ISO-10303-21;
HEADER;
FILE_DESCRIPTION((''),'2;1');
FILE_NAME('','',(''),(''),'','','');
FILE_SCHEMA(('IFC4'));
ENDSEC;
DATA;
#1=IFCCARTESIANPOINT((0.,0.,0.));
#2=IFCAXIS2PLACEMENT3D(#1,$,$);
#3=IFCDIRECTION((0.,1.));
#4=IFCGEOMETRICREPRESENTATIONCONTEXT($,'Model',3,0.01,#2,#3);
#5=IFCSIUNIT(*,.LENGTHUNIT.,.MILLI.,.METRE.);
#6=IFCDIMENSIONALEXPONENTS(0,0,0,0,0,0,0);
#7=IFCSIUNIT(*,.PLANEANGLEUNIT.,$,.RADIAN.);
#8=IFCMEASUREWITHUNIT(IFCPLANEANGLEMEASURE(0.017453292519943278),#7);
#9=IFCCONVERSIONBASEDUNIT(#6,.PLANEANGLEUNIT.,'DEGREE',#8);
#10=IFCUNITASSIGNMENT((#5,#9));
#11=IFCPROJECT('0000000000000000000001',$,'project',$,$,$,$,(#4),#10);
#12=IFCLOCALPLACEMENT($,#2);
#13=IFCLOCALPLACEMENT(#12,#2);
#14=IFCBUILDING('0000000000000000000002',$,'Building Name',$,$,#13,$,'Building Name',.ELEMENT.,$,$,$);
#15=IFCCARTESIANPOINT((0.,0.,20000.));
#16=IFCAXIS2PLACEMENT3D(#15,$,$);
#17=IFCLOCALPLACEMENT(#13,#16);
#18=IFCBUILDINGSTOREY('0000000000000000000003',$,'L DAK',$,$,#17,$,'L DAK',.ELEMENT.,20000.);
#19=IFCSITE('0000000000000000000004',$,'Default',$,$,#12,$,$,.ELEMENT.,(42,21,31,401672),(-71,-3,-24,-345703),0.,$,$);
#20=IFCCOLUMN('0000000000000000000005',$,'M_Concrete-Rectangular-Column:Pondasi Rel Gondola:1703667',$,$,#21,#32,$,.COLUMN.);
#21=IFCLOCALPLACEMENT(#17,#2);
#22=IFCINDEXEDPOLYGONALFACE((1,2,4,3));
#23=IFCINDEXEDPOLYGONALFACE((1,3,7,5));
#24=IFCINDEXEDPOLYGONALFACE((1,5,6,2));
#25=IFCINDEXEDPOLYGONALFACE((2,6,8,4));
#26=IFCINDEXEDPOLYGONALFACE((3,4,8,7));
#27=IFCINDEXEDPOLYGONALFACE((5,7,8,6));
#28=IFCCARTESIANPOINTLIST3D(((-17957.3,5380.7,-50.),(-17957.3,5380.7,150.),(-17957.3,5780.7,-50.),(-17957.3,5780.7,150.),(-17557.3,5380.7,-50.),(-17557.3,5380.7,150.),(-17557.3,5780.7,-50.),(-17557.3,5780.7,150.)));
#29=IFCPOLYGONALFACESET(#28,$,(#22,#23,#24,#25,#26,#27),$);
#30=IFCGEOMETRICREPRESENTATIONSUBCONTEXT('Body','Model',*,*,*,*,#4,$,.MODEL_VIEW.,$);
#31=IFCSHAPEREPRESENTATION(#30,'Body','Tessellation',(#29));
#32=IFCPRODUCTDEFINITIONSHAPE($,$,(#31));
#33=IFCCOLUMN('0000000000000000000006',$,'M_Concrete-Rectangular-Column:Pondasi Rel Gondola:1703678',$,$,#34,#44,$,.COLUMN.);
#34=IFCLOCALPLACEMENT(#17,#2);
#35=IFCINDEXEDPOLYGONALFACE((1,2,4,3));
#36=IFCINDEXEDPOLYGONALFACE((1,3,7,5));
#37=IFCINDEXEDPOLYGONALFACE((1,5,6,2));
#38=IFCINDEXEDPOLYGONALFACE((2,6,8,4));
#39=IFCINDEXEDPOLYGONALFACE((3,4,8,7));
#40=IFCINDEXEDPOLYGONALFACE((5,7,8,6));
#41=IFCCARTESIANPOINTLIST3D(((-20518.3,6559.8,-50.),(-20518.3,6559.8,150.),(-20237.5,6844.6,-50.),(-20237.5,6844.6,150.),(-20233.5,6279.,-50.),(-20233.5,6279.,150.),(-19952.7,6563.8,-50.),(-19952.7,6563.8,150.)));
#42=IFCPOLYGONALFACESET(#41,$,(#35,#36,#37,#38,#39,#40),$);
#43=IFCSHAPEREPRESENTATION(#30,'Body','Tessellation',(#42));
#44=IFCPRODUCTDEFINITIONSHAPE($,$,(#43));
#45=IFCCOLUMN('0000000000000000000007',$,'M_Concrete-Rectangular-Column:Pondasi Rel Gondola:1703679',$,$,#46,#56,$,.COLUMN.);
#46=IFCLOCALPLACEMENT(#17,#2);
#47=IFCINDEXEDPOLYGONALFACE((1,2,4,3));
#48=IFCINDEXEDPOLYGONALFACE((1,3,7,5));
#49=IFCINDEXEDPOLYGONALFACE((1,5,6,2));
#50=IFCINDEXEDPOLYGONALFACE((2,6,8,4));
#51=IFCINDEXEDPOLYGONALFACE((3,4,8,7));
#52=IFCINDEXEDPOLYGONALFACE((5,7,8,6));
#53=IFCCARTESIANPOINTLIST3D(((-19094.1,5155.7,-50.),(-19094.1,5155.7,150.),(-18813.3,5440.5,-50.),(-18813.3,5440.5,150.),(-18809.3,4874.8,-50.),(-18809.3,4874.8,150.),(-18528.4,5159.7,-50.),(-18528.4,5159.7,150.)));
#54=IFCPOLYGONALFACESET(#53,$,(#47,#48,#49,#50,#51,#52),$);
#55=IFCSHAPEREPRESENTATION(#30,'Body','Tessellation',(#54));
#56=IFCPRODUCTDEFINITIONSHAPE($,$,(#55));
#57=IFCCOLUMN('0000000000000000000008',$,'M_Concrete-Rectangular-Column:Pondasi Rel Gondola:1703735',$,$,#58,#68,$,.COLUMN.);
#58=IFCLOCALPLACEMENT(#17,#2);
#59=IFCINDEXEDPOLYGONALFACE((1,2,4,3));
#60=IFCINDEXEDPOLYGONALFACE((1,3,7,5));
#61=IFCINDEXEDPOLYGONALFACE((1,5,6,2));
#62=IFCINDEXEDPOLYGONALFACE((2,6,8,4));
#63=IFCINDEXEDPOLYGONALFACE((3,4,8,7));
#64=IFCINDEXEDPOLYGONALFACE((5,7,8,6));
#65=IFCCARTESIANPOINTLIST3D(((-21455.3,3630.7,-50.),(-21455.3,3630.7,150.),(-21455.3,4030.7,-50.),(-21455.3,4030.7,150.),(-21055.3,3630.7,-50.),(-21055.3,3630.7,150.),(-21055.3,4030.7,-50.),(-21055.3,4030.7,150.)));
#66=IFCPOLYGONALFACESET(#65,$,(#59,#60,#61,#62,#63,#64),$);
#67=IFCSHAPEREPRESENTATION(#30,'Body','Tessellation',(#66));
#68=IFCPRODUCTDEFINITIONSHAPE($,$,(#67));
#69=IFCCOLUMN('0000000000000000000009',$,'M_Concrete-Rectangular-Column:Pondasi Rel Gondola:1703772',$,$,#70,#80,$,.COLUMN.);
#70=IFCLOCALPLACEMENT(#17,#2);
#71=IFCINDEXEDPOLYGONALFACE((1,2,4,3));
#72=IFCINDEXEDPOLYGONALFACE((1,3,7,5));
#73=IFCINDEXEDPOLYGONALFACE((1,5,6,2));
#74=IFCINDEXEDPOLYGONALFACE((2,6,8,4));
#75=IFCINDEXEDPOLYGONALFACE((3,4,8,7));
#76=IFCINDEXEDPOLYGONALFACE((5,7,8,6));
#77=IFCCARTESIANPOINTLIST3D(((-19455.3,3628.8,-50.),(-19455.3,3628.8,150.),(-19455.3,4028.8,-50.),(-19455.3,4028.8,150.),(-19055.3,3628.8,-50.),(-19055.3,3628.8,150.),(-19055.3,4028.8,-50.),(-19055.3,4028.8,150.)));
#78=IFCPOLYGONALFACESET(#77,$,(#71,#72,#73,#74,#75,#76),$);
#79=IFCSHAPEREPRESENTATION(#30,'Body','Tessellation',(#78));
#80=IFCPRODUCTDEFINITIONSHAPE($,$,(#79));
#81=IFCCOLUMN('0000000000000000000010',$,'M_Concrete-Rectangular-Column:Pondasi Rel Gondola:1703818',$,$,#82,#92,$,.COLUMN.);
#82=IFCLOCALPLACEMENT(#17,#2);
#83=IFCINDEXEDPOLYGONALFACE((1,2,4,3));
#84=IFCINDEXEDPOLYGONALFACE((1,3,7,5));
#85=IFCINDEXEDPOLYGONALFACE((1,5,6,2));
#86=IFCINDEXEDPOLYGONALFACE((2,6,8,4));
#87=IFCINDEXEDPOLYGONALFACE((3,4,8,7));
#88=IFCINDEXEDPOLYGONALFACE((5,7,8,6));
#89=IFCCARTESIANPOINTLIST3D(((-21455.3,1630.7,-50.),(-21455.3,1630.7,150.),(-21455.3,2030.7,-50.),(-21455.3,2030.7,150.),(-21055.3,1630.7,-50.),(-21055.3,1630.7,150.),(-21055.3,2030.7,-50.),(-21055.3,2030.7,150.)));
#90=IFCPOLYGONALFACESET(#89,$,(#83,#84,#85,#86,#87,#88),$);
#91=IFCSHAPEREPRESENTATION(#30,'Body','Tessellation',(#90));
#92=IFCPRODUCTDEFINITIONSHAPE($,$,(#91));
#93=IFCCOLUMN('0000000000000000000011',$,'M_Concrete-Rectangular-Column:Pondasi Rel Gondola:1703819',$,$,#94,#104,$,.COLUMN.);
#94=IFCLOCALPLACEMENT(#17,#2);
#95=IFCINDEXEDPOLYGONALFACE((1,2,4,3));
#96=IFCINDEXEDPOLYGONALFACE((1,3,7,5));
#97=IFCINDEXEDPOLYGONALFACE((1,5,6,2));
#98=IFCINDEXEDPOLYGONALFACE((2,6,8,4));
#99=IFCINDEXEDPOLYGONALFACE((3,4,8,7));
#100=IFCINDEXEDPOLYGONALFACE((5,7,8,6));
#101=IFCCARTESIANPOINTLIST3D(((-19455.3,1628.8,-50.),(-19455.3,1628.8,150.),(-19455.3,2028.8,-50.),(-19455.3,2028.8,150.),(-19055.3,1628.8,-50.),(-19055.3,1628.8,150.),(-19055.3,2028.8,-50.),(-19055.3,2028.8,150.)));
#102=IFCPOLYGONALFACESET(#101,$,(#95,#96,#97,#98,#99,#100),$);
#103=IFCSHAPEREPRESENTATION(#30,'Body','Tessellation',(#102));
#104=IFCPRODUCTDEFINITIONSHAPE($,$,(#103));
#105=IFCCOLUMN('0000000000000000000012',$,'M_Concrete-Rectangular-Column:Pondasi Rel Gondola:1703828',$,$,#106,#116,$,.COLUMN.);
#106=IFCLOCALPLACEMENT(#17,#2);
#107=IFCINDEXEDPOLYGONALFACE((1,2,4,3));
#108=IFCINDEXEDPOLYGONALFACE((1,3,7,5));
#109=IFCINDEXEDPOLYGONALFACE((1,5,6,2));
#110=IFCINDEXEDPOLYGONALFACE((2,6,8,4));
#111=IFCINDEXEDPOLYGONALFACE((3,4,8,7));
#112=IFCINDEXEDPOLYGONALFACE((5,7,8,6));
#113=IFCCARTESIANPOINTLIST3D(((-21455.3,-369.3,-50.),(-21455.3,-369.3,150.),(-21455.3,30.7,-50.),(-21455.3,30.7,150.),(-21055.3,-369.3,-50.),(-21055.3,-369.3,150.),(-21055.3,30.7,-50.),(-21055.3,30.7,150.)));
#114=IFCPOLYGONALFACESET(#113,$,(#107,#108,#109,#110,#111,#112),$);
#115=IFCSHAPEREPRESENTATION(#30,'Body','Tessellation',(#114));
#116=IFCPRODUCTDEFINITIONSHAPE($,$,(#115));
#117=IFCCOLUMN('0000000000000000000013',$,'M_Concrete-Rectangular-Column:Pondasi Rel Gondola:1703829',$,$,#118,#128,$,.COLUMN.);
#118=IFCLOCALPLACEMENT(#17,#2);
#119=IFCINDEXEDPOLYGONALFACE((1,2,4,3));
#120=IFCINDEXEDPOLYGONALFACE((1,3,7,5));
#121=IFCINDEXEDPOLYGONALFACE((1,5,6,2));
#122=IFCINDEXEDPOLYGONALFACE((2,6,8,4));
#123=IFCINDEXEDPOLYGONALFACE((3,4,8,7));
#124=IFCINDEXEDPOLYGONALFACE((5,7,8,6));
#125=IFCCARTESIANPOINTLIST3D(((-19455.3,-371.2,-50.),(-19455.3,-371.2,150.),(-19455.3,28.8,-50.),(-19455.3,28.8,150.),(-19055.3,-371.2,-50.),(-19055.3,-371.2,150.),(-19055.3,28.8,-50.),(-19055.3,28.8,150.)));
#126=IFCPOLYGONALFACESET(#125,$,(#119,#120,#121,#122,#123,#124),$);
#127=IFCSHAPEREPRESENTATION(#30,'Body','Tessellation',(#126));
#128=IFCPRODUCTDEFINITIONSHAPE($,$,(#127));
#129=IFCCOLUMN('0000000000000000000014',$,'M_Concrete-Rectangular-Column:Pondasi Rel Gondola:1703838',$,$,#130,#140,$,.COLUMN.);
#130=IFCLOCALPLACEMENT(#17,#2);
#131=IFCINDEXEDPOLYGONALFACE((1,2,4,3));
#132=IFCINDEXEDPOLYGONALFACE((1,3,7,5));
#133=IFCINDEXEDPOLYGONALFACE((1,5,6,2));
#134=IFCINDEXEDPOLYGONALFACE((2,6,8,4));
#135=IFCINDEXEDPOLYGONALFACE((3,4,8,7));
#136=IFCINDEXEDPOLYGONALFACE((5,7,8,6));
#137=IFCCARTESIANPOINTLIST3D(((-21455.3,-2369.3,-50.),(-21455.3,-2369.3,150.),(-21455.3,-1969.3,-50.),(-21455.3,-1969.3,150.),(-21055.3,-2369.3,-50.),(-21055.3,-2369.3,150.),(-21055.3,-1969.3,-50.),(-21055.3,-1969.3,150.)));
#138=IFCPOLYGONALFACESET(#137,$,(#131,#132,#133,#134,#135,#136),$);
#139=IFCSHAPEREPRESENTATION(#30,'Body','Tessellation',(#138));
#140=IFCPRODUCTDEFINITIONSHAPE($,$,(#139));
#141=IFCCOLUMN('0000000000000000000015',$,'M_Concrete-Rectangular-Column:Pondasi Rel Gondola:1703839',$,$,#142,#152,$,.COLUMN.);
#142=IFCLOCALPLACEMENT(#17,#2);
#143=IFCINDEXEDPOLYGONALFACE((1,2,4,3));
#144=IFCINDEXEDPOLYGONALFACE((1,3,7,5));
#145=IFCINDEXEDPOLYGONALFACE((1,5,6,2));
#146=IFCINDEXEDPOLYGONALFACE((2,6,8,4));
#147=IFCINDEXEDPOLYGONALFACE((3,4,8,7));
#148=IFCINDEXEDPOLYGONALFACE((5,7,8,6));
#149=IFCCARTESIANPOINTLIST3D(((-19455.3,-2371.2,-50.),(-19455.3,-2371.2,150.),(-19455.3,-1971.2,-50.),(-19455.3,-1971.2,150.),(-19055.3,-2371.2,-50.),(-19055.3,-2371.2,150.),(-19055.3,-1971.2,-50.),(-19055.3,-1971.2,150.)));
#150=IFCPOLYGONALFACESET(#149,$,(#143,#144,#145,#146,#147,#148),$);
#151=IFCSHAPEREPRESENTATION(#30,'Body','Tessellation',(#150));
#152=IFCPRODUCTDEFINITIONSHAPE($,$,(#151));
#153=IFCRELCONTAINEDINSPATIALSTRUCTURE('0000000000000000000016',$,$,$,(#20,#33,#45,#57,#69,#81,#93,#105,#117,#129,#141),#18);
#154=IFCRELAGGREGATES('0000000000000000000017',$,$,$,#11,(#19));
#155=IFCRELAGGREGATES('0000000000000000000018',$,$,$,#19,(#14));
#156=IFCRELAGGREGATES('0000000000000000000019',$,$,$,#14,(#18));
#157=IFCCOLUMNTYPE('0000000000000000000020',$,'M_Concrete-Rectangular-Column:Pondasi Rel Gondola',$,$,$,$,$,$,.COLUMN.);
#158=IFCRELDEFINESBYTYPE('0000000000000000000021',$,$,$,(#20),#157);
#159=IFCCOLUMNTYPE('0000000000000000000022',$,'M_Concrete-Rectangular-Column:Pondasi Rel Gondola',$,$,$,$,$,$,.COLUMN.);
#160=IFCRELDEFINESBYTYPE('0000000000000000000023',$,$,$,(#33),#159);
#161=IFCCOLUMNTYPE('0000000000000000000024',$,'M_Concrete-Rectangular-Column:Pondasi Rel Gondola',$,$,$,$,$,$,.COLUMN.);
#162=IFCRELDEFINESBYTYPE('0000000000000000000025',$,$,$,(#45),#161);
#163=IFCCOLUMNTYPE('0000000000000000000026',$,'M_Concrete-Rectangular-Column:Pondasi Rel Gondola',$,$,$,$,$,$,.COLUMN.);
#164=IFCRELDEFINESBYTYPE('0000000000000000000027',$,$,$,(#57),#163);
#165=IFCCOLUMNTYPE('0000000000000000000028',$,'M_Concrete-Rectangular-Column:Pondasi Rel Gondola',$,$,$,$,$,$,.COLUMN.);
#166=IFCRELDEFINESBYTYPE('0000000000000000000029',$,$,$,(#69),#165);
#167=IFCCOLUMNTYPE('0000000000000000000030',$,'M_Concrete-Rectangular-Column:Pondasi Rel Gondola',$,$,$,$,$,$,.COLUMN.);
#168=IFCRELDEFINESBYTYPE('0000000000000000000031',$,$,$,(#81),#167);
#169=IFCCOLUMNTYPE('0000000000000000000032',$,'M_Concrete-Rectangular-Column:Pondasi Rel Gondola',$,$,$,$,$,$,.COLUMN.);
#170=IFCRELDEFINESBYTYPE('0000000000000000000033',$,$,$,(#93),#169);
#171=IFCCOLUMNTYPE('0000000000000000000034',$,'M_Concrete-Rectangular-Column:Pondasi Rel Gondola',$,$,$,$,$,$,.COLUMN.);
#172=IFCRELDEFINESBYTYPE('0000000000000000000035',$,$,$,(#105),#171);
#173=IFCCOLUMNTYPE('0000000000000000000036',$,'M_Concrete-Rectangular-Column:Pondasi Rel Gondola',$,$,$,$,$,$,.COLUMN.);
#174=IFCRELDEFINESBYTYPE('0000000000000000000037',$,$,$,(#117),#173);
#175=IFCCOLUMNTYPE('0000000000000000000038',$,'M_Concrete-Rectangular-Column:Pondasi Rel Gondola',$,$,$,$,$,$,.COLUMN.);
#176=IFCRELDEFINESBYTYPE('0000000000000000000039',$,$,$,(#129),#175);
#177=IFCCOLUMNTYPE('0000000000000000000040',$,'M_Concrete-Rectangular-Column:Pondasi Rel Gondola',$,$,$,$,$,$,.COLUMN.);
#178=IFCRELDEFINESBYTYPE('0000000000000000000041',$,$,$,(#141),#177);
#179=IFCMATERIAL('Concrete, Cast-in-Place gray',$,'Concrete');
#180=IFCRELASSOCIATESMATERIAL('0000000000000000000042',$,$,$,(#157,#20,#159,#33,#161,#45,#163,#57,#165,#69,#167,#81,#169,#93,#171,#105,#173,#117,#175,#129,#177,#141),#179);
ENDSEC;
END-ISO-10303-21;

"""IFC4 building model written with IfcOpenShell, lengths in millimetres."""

from ifc_helpers import new_model, entity, si_unit, converted_unit, direction, frame, origin, place, context, subcontext, project, spatial, indexed_curve, outline, extrude, source, transform, mapped, material, type_object, type_shapes, element, save


model = new_model("IFC4")

# Units and contexts
model_context = context("Model", 3, precision=0.01, world=origin(), true_north=direction((0.0, 1.0)))
body_context = subcontext(model_context, "Body", "Model", "MODEL_VIEW")
ifc_project = project(units=[si_unit("LENGTHUNIT", "METRE", prefix="MILLI"), converted_unit("PLANEANGLEUNIT", "DEGREE", entity("IfcPlaneAngleMeasure", 0.017453292519943278), si_unit("PLANEANGLEUNIT", "RADIAN"), dimensions=[0, 0, 0, 0, 0, 0, 0])], contexts=[model_context])

# Site, building, storey
site_placement = place(None, origin())
site = spatial("IfcSite", under=ifc_project, at=site_placement, Name="Default", CompositionType="ELEMENT", RefLatitude=(42, 21, 31, 401672), RefLongitude=(-71, -3, -24, -345703), RefElevation=0.0)
building_placement = place(site_placement, origin())
building = spatial("IfcBuilding", under=site, at=building_placement, Name="Building Name", LongName="Building Name", CompositionType="ELEMENT")
storey_placement = place(building_placement, frame((0.0, 0.0, 20000.0)))
storey = spatial("IfcBuildingStorey", under=building, at=storey_placement, Name="L DAK", LongName="L DAK", CompositionType="ELEMENT", Elevation=20000.0)

# Columns
ifc_material = material(Name="Concrete, Cast-in-Place gray", Category="Concrete")
column_type_1 = type_object("IfcColumnType", Name="M_Concrete-Rectangular-Column:Pondasi Rel Gondola", PredefinedType="COLUMN", material=ifc_material)
shared_shape_1 = source(origin(), body_context, "Body", "SweptSolid", [
    extrude(outline(indexed_curve([(-200.0, -200.0), (200.0, -200.0), (200.0, 200.0), (-200.0, 200.0), (-200.0, -200.0)], self_intersect=False)), frame((-17757.3, 5580.7, 19950.0), z_axis=(0.0, 0.0, 1.0), x_axis=(-1.0, 0.0, 0.0)), (0.0, 0.0, 1.0), 200.0),
])
type_shapes(column_type_1, [shared_shape_1])
column_1_placement = place(storey_placement, frame((0.0, 0.0, -20000.0)))
element("IfcColumn", 1, at=column_1_placement, inside=storey, type_object=column_type_1, material=ifc_material, Name="M_Concrete-Rectangular-Column:Pondasi Rel Gondola:1703667", PredefinedType="COLUMN", context=body_context, shape_type="MappedRepresentation", body=[
    mapped(shared_shape_1, transform((0.0, 0.0, 0.0), scale=1.0)),
])
column_type_2 = type_object("IfcColumnType", Name="M_Concrete-Rectangular-Column:Pondasi Rel Gondola", PredefinedType="COLUMN", material=ifc_material)
shared_shape_2 = source(origin(), body_context, "Body", "SweptSolid", [
    extrude(outline(indexed_curve([(-200.0, -200.0), (200.0, -200.0), (200.0, 200.0), (-200.0, 200.0), (-200.0, -200.0)], self_intersect=False)), frame((-20235.5, 6561.8, 19950.0), z_axis=(0.0, 0.0, 1.0), x_axis=(-0.702064, -0.712114, 0.0)), (0.0, 0.0, 1.0), 200.0),
])
type_shapes(column_type_2, [shared_shape_2])
column_2_placement = place(storey_placement, frame((0.0, 0.0, -20000.0)))
element("IfcColumn", 2, at=column_2_placement, inside=storey, type_object=column_type_2, material=ifc_material, Name="M_Concrete-Rectangular-Column:Pondasi Rel Gondola:1703678", PredefinedType="COLUMN", context=body_context, shape_type="MappedRepresentation", body=[
    mapped(shared_shape_2, transform((0.0, 0.0, 0.0), scale=1.0)),
])
column_type_3 = type_object("IfcColumnType", Name="M_Concrete-Rectangular-Column:Pondasi Rel Gondola", PredefinedType="COLUMN", material=ifc_material)
shared_shape_3 = source(origin(), body_context, "Body", "SweptSolid", [
    extrude(outline(indexed_curve([(-200.0, -200.0), (200.0, -200.0), (200.0, 200.0), (-200.0, 200.0), (-200.0, -200.0)], self_intersect=False)), frame((-18811.3, 5157.7, 19950.0), z_axis=(0.0, 0.0, 1.0), x_axis=(-0.702064, -0.712114, 0.0)), (0.0, 0.0, 1.0), 200.0),
])
type_shapes(column_type_3, [shared_shape_3])
column_3_placement = place(storey_placement, frame((0.0, 0.0, -20000.0)))
element("IfcColumn", 3, at=column_3_placement, inside=storey, type_object=column_type_3, material=ifc_material, Name="M_Concrete-Rectangular-Column:Pondasi Rel Gondola:1703679", PredefinedType="COLUMN", context=body_context, shape_type="MappedRepresentation", body=[
    mapped(shared_shape_3, transform((0.0, 0.0, 0.0), scale=1.0)),
])
column_type_4 = type_object("IfcColumnType", Name="M_Concrete-Rectangular-Column:Pondasi Rel Gondola", PredefinedType="COLUMN", material=ifc_material)
shared_shape_4 = source(origin(), body_context, "Body", "SweptSolid", [
    extrude(outline(indexed_curve([(-200.0, -200.0), (200.0, -200.0), (200.0, 200.0), (-200.0, 200.0), (-200.0, -200.0)], self_intersect=False)), frame((-21255.3, 3830.7, 19950.0), z_axis=(0.0, 0.0, 1.0), x_axis=(-1.0, 0.0, 0.0)), (0.0, 0.0, 1.0), 200.0),
])
type_shapes(column_type_4, [shared_shape_4])
column_4_placement = place(storey_placement, frame((0.0, 0.0, -20000.0)))
element("IfcColumn", 4, at=column_4_placement, inside=storey, type_object=column_type_4, material=ifc_material, Name="M_Concrete-Rectangular-Column:Pondasi Rel Gondola:1703735", PredefinedType="COLUMN", context=body_context, shape_type="MappedRepresentation", body=[
    mapped(shared_shape_4, transform((0.0, 0.0, 0.0), scale=1.0)),
])
column_type_5 = type_object("IfcColumnType", Name="M_Concrete-Rectangular-Column:Pondasi Rel Gondola", PredefinedType="COLUMN", material=ifc_material)
shared_shape_5 = source(origin(), body_context, "Body", "SweptSolid", [
    extrude(outline(indexed_curve([(-200.0, -200.0), (200.0, -200.0), (200.0, 200.0), (-200.0, 200.0), (-200.0, -200.0)], self_intersect=False)), frame((-19255.3, 3828.8, 19950.0), z_axis=(0.0, 0.0, 1.0), x_axis=(-1.0, 0.0, 0.0)), (0.0, 0.0, 1.0), 200.0),
])
type_shapes(column_type_5, [shared_shape_5])
column_5_placement = place(storey_placement, frame((0.0, 0.0, -20000.0)))
element("IfcColumn", 5, at=column_5_placement, inside=storey, type_object=column_type_5, material=ifc_material, Name="M_Concrete-Rectangular-Column:Pondasi Rel Gondola:1703772", PredefinedType="COLUMN", context=body_context, shape_type="MappedRepresentation", body=[
    mapped(shared_shape_5, transform((0.0, 0.0, 0.0), scale=1.0)),
])
column_type_6 = type_object("IfcColumnType", Name="M_Concrete-Rectangular-Column:Pondasi Rel Gondola", PredefinedType="COLUMN", material=ifc_material)
shared_shape_6 = source(origin(), body_context, "Body", "SweptSolid", [
    extrude(outline(indexed_curve([(-200.0, -200.0), (200.0, -200.0), (200.0, 200.0), (-200.0, 200.0), (-200.0, -200.0)], self_intersect=False)), frame((-21255.3, 1830.7, 19950.0), z_axis=(0.0, 0.0, 1.0), x_axis=(-1.0, 0.0, 0.0)), (0.0, 0.0, 1.0), 200.0),
])
type_shapes(column_type_6, [shared_shape_6])
column_6_placement = place(storey_placement, frame((0.0, 0.0, -20000.0)))
element("IfcColumn", 6, at=column_6_placement, inside=storey, type_object=column_type_6, material=ifc_material, Name="M_Concrete-Rectangular-Column:Pondasi Rel Gondola:1703818", PredefinedType="COLUMN", context=body_context, shape_type="MappedRepresentation", body=[
    mapped(shared_shape_6, transform((0.0, 0.0, 0.0), scale=1.0)),
])
column_type_7 = type_object("IfcColumnType", Name="M_Concrete-Rectangular-Column:Pondasi Rel Gondola", PredefinedType="COLUMN", material=ifc_material)
shared_shape_7 = source(origin(), body_context, "Body", "SweptSolid", [
    extrude(outline(indexed_curve([(-200.0, -200.0), (200.0, -200.0), (200.0, 200.0), (-200.0, 200.0), (-200.0, -200.0)], self_intersect=False)), frame((-19255.3, 1828.8, 19950.0), z_axis=(0.0, 0.0, 1.0), x_axis=(-1.0, 0.0, 0.0)), (0.0, 0.0, 1.0), 200.0),
])
type_shapes(column_type_7, [shared_shape_7])
column_7_placement = place(storey_placement, frame((0.0, 0.0, -20000.0)))
element("IfcColumn", 7, at=column_7_placement, inside=storey, type_object=column_type_7, material=ifc_material, Name="M_Concrete-Rectangular-Column:Pondasi Rel Gondola:1703819", PredefinedType="COLUMN", context=body_context, shape_type="MappedRepresentation", body=[
    mapped(shared_shape_7, transform((0.0, 0.0, 0.0), scale=1.0)),
])
column_type_8 = type_object("IfcColumnType", Name="M_Concrete-Rectangular-Column:Pondasi Rel Gondola", PredefinedType="COLUMN", material=ifc_material)
shared_shape_8 = source(origin(), body_context, "Body", "SweptSolid", [
    extrude(outline(indexed_curve([(-200.0, -200.0), (200.0, -200.0), (200.0, 200.0), (-200.0, 200.0), (-200.0, -200.0)], self_intersect=False)), frame((-21255.3, -169.3, 19950.0), z_axis=(0.0, 0.0, 1.0), x_axis=(-1.0, 0.0, 0.0)), (0.0, 0.0, 1.0), 200.0),
])
type_shapes(column_type_8, [shared_shape_8])
column_8_placement = place(storey_placement, frame((0.0, 0.0, -20000.0)))
element("IfcColumn", 8, at=column_8_placement, inside=storey, type_object=column_type_8, material=ifc_material, Name="M_Concrete-Rectangular-Column:Pondasi Rel Gondola:1703828", PredefinedType="COLUMN", context=body_context, shape_type="MappedRepresentation", body=[
    mapped(shared_shape_8, transform((0.0, 0.0, 0.0), scale=1.0)),
])
column_type_9 = type_object("IfcColumnType", Name="M_Concrete-Rectangular-Column:Pondasi Rel Gondola", PredefinedType="COLUMN", material=ifc_material)
shared_shape_9 = source(origin(), body_context, "Body", "SweptSolid", [
    extrude(outline(indexed_curve([(-200.0, -200.0), (200.0, -200.0), (200.0, 200.0), (-200.0, 200.0), (-200.0, -200.0)], self_intersect=False)), frame((-19255.3, -171.2, 19950.0), z_axis=(0.0, 0.0, 1.0), x_axis=(-1.0, 0.0, 0.0)), (0.0, 0.0, 1.0), 200.0),
])
type_shapes(column_type_9, [shared_shape_9])
column_9_placement = place(storey_placement, frame((0.0, 0.0, -20000.0)))
element("IfcColumn", 9, at=column_9_placement, inside=storey, type_object=column_type_9, material=ifc_material, Name="M_Concrete-Rectangular-Column:Pondasi Rel Gondola:1703829", PredefinedType="COLUMN", context=body_context, shape_type="MappedRepresentation", body=[
    mapped(shared_shape_9, transform((0.0, 0.0, 0.0), scale=1.0)),
])
column_type_10 = type_object("IfcColumnType", Name="M_Concrete-Rectangular-Column:Pondasi Rel Gondola", PredefinedType="COLUMN", material=ifc_material)
shared_shape_10 = source(origin(), body_context, "Body", "SweptSolid", [
    extrude(outline(indexed_curve([(-200.0, -200.0), (200.0, -200.0), (200.0, 200.0), (-200.0, 200.0), (-200.0, -200.0)], self_intersect=False)), frame((-21255.3, -2169.3, 19950.0), z_axis=(0.0, 0.0, 1.0), x_axis=(-1.0, 0.0, 0.0)), (0.0, 0.0, 1.0), 200.0),
])
type_shapes(column_type_10, [shared_shape_10])
column_10_placement = place(storey_placement, frame((0.0, 0.0, -20000.0)))
element("IfcColumn", 10, at=column_10_placement, inside=storey, type_object=column_type_10, material=ifc_material, Name="M_Concrete-Rectangular-Column:Pondasi Rel Gondola:1703838", PredefinedType="COLUMN", context=body_context, shape_type="MappedRepresentation", body=[
    mapped(shared_shape_10, transform((0.0, 0.0, 0.0), scale=1.0)),
])
column_type_11 = type_object("IfcColumnType", Name="M_Concrete-Rectangular-Column:Pondasi Rel Gondola", PredefinedType="COLUMN", material=ifc_material)
shared_shape_11 = source(origin(), body_context, "Body", "SweptSolid", [
    extrude(outline(indexed_curve([(-200.0, -200.0), (200.0, -200.0), (200.0, 200.0), (-200.0, 200.0), (-200.0, -200.0)], self_intersect=False)), frame((-19255.3, -2171.2, 19950.0), z_axis=(0.0, 0.0, 1.0), x_axis=(-1.0, 0.0, 0.0)), (0.0, 0.0, 1.0), 200.0),
])
type_shapes(column_type_11, [shared_shape_11])
column_11_placement = place(storey_placement, frame((0.0, 0.0, -20000.0)))
element("IfcColumn", 11, at=column_11_placement, inside=storey, type_object=column_type_11, material=ifc_material, Name="M_Concrete-Rectangular-Column:Pondasi Rel Gondola:1703839", PredefinedType="COLUMN", context=body_context, shape_type="MappedRepresentation", body=[
    mapped(shared_shape_11, transform((0.0, 0.0, 0.0), scale=1.0)),
])

save(model, "model.ifc")
